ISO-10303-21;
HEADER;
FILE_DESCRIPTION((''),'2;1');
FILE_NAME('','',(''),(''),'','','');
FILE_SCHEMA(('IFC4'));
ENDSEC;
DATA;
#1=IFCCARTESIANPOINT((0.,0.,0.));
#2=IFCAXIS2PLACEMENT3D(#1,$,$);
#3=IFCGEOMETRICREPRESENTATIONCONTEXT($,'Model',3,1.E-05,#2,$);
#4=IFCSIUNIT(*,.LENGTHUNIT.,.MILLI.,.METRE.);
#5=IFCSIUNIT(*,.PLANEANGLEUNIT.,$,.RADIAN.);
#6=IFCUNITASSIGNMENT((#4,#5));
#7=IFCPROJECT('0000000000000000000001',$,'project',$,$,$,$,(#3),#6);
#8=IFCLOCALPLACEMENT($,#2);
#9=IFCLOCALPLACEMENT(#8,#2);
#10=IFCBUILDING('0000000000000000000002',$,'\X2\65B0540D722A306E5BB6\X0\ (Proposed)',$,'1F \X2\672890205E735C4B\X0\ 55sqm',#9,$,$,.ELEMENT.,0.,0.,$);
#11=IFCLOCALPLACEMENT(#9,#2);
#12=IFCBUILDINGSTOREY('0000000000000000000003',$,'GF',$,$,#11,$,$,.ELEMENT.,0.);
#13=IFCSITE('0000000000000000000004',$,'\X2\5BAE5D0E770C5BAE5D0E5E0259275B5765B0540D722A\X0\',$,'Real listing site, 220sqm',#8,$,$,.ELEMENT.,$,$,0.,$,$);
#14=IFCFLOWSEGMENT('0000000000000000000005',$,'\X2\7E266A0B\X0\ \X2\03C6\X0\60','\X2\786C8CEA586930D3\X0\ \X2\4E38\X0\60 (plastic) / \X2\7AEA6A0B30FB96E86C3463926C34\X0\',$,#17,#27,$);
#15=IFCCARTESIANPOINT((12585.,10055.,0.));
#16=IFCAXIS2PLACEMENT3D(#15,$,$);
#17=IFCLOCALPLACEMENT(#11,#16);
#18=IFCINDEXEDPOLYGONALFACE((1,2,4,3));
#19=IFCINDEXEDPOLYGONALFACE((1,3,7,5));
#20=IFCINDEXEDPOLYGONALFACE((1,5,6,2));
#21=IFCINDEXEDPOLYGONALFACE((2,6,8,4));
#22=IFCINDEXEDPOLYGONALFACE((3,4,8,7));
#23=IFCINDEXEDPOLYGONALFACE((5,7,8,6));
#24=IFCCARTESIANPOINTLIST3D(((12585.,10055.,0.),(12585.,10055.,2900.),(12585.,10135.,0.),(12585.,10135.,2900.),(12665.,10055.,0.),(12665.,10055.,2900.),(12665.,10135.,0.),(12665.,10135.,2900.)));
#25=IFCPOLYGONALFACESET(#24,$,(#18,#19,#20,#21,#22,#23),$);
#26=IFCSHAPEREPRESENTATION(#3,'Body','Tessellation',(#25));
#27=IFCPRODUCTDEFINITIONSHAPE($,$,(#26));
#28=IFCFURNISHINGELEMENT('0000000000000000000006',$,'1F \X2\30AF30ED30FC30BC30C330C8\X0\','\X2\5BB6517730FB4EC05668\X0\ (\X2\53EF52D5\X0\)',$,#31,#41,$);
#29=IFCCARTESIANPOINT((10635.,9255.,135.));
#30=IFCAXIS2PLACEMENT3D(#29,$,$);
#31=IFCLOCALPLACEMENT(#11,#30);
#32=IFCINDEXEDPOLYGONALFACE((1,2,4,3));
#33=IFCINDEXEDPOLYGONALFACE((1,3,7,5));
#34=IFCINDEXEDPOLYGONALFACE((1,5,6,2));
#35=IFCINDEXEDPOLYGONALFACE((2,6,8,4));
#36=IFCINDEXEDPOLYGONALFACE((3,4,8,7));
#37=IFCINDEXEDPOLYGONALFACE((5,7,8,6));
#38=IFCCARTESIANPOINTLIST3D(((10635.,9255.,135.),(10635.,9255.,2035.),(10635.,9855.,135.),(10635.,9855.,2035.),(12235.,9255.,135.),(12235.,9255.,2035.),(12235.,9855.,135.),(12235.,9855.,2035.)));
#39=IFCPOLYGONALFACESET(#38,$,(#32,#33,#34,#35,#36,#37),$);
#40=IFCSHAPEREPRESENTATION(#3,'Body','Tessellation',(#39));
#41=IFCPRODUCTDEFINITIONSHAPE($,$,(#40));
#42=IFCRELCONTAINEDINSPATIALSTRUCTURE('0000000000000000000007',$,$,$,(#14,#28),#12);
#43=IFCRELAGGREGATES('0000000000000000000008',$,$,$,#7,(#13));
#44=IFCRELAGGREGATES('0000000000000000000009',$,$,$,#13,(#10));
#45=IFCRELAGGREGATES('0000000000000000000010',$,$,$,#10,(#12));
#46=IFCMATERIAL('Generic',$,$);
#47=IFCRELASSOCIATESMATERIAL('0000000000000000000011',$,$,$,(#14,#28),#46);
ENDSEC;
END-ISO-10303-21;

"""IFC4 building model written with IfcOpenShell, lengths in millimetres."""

from ifc_helpers import new_model, si_unit, frame, frame_2d, origin, place, context, project, spatial, rectangle, extrude, material, element, save


model = new_model("IFC4")

# Units and contexts
model_context = context("Model", 3, precision=1e-05, world=origin())
ifc_project = project(units=[si_unit("LENGTHUNIT", "METRE", prefix="MILLI"), si_unit("PLANEANGLEUNIT", "RADIAN")], contexts=[model_context])

# Site, building, storey
site_placement = place(None, origin())
site = spatial("IfcSite", under=ifc_project, at=site_placement, Name="宮崎県宮崎市大字新名爪", ObjectType="Real listing site, 220sqm", CompositionType="ELEMENT", RefElevation=0.0)
building_placement = place(site_placement, origin())
building = spatial("IfcBuilding", under=site, at=building_placement, Name="新名爪の家 (Proposed)", ObjectType="1F 木造平屋 55sqm", CompositionType="ELEMENT", ElevationOfRefHeight=0.0, ElevationOfTerrain=0.0)
storey_placement = place(building_placement, origin())
storey = spatial("IfcBuildingStorey", under=building, at=storey_placement, Name="GF", CompositionType="ELEMENT", Elevation=0.0)

# Shared definitions
ifc_material_1 = material(Name="Generic")

# Flow segment
flow_segment_placement = place(storey_placement, frame((12585.0, 10055.0, 0.0)))
element("IfcFlowSegment", 1, at=flow_segment_placement, inside=storey, material=ifc_material_1, Name="縦樋 φ60", Description="硬質塩ビ 丸60 (plastic) / 竪樋・雨水排水", context=model_context, shape_type="SweptSolid", body=[
    extrude(rectangle(XDim=80.0, YDim=80.0, at=frame_2d((40.0, 40.0))), frame((12585.0, 10055.0, 0.0)), (0.0, 0.0, 1.0), 2900.0),
])

# Furnishing element
furnishing_placement = place(storey_placement, frame((10635.0, 9255.0, 135.0)))
element("IfcFurnishingElement", 2, at=furnishing_placement, inside=storey, material=ifc_material_1, Name="1F クローゼット", Description="家具・什器 (可動)", context=model_context, shape_type="SweptSolid", body=[
    extrude(rectangle(XDim=1600.0, YDim=600.0, at=frame_2d((800.0, 300.0))), frame((10635.0, 9255.0, 135.0)), (0.0, 0.0, 1.0), 1900.0),
])

save(model, "model.ifc")
